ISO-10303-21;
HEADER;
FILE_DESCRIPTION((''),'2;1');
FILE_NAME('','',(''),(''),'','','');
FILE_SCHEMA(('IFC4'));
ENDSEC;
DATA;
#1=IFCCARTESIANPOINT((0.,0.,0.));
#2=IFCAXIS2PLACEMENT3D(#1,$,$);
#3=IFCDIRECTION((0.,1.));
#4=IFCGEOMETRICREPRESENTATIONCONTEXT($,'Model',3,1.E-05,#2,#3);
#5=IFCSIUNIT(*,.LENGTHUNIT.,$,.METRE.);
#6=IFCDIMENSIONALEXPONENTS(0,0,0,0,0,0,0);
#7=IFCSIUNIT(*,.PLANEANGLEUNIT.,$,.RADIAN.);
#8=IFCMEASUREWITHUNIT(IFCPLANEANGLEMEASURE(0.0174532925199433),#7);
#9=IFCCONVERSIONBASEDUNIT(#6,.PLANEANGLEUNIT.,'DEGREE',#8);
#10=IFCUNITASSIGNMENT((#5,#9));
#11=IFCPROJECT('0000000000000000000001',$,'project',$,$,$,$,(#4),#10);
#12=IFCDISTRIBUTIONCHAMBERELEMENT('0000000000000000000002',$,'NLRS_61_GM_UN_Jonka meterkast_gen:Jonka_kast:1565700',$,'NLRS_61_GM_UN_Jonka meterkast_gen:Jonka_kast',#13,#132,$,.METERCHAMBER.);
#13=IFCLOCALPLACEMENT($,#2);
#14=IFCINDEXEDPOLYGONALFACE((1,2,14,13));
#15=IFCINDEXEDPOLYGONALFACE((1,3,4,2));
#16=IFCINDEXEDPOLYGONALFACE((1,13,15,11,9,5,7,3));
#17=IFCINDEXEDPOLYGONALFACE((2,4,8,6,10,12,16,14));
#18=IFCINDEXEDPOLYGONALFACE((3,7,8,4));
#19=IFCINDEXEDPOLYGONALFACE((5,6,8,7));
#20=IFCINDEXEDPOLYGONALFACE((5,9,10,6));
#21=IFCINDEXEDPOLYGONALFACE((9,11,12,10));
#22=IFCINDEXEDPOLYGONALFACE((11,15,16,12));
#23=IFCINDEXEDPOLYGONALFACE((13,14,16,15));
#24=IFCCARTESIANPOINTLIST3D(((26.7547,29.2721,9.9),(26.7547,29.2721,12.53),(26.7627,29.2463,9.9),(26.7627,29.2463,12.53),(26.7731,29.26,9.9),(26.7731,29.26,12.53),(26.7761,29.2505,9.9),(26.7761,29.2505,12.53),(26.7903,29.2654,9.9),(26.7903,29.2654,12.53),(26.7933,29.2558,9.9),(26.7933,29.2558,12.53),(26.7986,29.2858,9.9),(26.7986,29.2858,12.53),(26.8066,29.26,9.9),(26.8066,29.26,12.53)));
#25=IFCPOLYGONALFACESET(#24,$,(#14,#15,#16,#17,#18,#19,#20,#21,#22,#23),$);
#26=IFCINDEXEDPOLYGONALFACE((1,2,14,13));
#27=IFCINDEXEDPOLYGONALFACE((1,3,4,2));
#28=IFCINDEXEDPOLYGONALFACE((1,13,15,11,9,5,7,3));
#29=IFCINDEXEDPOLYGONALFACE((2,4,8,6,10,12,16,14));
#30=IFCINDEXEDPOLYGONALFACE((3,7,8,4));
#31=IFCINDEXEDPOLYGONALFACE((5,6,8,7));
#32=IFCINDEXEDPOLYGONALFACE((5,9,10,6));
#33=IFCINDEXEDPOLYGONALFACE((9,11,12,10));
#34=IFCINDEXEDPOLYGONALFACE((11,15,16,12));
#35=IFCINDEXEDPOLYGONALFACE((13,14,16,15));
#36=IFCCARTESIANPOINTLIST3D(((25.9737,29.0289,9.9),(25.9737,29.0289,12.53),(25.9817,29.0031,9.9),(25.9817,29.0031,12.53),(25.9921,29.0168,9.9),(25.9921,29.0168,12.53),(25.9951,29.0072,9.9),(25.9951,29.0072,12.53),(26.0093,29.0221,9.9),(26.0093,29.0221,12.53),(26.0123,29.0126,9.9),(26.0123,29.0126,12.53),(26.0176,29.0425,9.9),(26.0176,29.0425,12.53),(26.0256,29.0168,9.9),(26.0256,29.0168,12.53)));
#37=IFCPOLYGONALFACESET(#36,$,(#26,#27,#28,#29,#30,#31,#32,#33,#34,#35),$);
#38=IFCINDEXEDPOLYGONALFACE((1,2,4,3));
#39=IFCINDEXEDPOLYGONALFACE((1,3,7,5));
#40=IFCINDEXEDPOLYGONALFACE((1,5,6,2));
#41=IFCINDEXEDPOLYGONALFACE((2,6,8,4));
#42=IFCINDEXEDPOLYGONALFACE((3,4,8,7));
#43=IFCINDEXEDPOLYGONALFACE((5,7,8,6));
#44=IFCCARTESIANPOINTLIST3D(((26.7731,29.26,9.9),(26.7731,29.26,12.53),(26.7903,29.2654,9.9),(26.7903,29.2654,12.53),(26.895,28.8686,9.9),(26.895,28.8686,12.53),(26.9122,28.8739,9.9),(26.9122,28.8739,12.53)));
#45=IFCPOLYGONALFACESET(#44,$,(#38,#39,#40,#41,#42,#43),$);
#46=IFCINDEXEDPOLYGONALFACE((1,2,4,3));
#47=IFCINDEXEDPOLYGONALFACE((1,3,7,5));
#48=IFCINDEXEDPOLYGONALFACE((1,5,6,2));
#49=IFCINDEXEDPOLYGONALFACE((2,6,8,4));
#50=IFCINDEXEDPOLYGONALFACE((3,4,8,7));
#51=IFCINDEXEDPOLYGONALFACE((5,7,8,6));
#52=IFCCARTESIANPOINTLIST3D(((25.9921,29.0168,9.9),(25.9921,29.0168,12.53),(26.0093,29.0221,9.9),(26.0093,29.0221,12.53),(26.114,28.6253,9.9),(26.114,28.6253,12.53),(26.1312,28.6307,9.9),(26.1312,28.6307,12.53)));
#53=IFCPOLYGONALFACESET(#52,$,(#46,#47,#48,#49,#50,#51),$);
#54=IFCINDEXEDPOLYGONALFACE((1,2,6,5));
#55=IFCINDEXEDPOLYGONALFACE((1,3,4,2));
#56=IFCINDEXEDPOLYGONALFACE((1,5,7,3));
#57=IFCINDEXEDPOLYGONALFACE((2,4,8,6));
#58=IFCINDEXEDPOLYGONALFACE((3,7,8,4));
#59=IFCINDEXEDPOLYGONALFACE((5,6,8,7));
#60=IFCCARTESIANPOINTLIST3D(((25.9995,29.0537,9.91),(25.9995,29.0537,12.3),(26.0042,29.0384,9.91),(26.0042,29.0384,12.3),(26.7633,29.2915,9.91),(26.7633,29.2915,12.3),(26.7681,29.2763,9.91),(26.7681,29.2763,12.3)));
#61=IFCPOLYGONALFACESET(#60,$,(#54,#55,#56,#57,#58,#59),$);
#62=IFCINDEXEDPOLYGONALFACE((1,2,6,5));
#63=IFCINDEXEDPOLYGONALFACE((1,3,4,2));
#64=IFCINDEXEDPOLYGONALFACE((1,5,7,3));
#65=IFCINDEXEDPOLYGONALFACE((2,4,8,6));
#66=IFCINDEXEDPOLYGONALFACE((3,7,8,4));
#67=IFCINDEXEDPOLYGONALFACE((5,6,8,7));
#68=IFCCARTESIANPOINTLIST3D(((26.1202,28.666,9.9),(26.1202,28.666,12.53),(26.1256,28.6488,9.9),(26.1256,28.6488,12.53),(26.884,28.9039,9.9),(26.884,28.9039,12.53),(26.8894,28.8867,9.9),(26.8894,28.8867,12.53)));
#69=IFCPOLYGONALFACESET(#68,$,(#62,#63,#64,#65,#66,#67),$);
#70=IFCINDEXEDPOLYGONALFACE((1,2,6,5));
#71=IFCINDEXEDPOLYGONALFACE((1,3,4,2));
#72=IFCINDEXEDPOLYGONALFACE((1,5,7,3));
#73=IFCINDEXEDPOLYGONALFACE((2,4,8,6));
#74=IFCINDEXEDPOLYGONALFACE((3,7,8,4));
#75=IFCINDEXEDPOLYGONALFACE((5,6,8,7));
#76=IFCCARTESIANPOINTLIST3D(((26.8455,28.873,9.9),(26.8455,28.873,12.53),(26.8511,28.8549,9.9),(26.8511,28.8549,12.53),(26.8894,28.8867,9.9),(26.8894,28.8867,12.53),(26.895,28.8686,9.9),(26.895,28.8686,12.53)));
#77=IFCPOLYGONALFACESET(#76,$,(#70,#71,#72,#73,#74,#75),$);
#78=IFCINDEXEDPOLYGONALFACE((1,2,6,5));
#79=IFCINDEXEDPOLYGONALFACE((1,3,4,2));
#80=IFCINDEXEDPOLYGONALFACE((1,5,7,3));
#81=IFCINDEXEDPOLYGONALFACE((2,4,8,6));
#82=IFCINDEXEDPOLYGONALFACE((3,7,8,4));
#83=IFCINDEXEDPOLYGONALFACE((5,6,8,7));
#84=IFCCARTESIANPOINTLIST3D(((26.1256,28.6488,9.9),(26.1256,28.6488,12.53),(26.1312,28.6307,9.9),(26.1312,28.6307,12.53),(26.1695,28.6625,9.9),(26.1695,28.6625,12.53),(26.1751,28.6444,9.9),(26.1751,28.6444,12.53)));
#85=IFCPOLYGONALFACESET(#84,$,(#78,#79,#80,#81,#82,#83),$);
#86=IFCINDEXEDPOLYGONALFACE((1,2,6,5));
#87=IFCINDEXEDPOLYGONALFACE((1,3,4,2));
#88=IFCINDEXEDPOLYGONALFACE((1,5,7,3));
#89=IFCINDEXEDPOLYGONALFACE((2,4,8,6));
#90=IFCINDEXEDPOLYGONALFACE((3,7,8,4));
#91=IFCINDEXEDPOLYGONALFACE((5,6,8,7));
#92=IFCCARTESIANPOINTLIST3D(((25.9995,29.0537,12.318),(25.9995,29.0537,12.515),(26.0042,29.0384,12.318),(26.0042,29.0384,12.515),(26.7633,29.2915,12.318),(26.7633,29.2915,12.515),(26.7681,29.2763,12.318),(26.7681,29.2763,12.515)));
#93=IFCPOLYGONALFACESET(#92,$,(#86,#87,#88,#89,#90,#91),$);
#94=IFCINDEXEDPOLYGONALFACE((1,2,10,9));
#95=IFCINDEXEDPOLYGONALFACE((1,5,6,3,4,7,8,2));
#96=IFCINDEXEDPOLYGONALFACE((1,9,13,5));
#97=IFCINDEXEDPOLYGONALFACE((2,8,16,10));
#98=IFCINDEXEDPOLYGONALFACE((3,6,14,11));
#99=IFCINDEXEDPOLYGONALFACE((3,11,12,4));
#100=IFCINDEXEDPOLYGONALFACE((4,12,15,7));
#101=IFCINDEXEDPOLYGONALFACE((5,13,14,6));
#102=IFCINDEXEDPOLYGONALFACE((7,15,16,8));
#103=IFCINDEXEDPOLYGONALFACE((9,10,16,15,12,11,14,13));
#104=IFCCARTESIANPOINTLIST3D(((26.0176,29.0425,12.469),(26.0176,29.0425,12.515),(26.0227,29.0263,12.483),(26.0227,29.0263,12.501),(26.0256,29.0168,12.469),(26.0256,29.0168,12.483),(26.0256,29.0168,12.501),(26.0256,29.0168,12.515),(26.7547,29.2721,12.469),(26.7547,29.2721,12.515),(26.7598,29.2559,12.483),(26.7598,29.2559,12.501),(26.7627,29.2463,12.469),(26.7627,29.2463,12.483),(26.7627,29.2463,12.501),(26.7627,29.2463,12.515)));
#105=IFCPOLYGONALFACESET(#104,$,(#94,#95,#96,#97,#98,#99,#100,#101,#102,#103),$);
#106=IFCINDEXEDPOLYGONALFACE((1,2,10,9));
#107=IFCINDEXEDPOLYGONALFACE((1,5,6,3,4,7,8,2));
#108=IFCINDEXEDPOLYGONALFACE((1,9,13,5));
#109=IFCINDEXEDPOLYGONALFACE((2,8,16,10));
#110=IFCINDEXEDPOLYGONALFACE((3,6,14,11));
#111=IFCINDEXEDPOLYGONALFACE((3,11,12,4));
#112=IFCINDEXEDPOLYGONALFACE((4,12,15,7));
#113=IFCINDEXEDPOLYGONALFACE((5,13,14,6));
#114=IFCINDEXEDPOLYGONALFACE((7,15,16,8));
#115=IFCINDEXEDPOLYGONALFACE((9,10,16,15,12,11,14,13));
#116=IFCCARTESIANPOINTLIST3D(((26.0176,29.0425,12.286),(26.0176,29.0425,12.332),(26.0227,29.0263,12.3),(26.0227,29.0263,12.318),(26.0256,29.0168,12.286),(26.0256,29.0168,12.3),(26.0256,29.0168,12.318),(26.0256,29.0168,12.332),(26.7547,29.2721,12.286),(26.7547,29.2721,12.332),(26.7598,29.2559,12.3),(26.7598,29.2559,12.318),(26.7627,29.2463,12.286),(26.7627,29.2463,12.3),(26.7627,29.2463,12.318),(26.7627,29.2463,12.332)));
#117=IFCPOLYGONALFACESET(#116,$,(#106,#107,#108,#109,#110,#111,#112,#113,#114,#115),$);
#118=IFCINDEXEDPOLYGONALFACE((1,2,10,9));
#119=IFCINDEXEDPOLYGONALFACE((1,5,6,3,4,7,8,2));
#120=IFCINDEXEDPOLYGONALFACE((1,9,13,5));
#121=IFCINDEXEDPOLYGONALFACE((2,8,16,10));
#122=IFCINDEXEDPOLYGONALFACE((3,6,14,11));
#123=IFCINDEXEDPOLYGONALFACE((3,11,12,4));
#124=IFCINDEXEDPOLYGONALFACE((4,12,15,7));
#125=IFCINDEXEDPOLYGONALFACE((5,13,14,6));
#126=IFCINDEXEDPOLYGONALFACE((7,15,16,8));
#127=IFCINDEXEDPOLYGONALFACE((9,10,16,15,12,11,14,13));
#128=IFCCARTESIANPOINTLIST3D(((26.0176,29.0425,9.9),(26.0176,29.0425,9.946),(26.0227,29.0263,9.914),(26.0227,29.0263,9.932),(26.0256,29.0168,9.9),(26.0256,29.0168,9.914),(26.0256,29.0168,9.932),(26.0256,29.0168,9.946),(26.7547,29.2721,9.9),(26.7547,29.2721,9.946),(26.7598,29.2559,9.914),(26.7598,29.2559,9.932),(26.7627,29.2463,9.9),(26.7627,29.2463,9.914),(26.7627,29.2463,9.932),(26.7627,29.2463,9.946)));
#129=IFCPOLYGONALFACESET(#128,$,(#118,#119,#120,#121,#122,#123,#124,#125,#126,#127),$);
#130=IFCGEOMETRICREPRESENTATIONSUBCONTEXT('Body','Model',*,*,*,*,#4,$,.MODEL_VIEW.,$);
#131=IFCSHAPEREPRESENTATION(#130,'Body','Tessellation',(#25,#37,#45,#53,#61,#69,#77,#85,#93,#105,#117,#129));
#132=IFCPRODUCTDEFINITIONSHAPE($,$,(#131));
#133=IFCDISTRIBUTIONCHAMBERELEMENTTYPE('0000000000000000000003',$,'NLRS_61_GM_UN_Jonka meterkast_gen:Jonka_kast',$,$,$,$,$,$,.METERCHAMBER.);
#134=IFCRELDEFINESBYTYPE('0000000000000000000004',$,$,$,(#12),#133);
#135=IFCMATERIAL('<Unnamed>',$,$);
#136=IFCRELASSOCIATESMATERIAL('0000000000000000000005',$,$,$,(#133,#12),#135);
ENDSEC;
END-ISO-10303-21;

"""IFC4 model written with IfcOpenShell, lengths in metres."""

from ifc_helpers import new_model, entity, si_unit, converted_unit, direction, frame, origin, place, context, subcontext, project, indexed_curve, outline, extrude, source, transform, mapped, material, type_object, type_shapes, element, save


model = new_model("IFC4")

# Units and contexts
model_context = context("Model", 3, precision=1e-05, world=origin(), true_north=direction((0.0, 1.0)))
body_context = subcontext(model_context, "Body", "Model", "MODEL_VIEW")
ifc_project = project(units=[si_unit("LENGTHUNIT", "METRE"), converted_unit("PLANEANGLEUNIT", "DEGREE", entity("IfcPlaneAngleMeasure", 0.0174532925199433), si_unit("PLANEANGLEUNIT", "RADIAN"), dimensions=[0, 0, 0, 0, 0, 0, 0])], contexts=[model_context])

# Distribution chamber element
ifc_material = material(Name="<Unnamed>")
distribution_chamber_element_type = type_object("IfcDistributionChamberElementType", Name="NLRS_61_GM_UN_Jonka meterkast_gen:Jonka_kast", PredefinedType="METERCHAMBER", material=ifc_material)
shared_shape_1 = source(origin(), body_context, "Body", "SweptSolid", [
    extrude(outline(indexed_curve([(-0.0093, -0.023), (0.0178, -0.023), (0.0178, 0.023), (-0.0093, 0.023), (-0.0093, 0.009), (0.0007, 0.009), (0.0007, -0.009), (-0.0093, -0.009), (-0.0093, -0.023)], self_intersect=False)), frame((-0.409, -0.4092, 0.0), z_axis=(0.0, 0.0, 1.0), x_axis=(0.0, -1.0, 0.0)), (0.0, 0.0, 1.0), 2.63),
    extrude(outline(indexed_curve([(-0.0093, -0.023), (0.0178, -0.023), (0.0178, 0.023), (-0.0093, 0.023), (-0.0093, 0.009), (0.0007, 0.009), (0.0007, -0.009), (-0.0093, -0.009), (-0.0093, -0.023)], self_intersect=False)), frame((0.409, -0.4092, 0.0), z_axis=(0.0, 0.0, 1.0), x_axis=(0.0, -1.0, 0.0)), (0.0, 0.0, 1.0), 2.63),
    extrude(outline(indexed_curve([(-0.205, -0.009), (0.205, -0.009), (0.205, 0.009), (-0.205, 0.009), (-0.205, -0.009)], self_intersect=False)), frame((-0.409, -0.205, 0.0), z_axis=(0.0, 0.0, 1.0), x_axis=(0.0, -1.0, 0.0)), (0.0, 0.0, 1.0), 2.63),
    extrude(outline(indexed_curve([(-0.205, -0.009), (0.205, -0.009), (0.205, 0.009), (-0.205, 0.009), (-0.205, -0.009)], self_intersect=False)), frame((0.409, -0.205, 0.0), z_axis=(0.0, 0.0, 1.0), x_axis=(0.0, -1.0, 0.0)), (0.0, 0.0, 1.0), 2.63),
    extrude(outline(indexed_curve([(-0.4, -0.008), (0.4, -0.008), (0.4, 0.008), (-0.4, 0.008), (-0.4, -0.008)], self_intersect=False)), frame((0.0, -0.435, 0.01), z_axis=(0.0, 0.0, 1.0), x_axis=(-1.0, 0.0, 0.0)), (0.0, 0.0, 1.0), 2.39),
    extrude(outline(indexed_curve([(-0.4, -0.009), (0.4, -0.009), (0.4, 0.009), (-0.4, 0.009), (-0.4, -0.009)], self_intersect=False)), frame((0.0, -0.028, 0.0), z_axis=(0.0, 0.0, 1.0), x_axis=(-1.0, 0.0, 0.0)), (0.0, 0.0, 1.0), 2.63),
    extrude(outline(indexed_curve([(-0.023, -0.0095), (0.023, -0.0095), (0.023, 0.0095), (-0.023, 0.0095), (-0.023, -0.0095)], self_intersect=False)), frame((-0.377, -0.0095, 0.0), z_axis=(0.0, 0.0, 1.0), x_axis=(-1.0, 0.0, 0.0)), (0.0, 0.0, 1.0), 2.63),
    extrude(outline(indexed_curve([(-0.023, -0.0095), (0.023, -0.0095), (0.023, 0.0095), (-0.023, 0.0095), (-0.023, -0.0095)], self_intersect=False)), frame((0.377, -0.0095, 0.0), z_axis=(0.0, 0.0, 1.0), x_axis=(-1.0, 0.0, 0.0)), (0.0, 0.0, 1.0), 2.63),
    extrude(outline(indexed_curve([(-0.4, -0.008), (0.4, -0.008), (0.4, 0.008), (-0.4, 0.008), (-0.4, -0.008)], self_intersect=False)), frame((0.0, -0.435, 2.418), z_axis=(0.0, 0.0, 1.0), x_axis=(-1.0, 0.0, 0.0)), (0.0, 0.0, 1.0), 0.197),
    extrude(outline(indexed_curve([(-0.023, -0.0178), (0.023, -0.0178), (0.023, 0.0093), (0.009, 0.0093), (0.009, -0.0007), (-0.009, -0.0007), (-0.009, 0.0093), (-0.023, 0.0093), (-0.023, -0.0178)], self_intersect=False)), frame((-0.386, -0.4092, 2.592), z_axis=(1.0, 0.0, 0.0), x_axis=(0.0, 0.0, -1.0)), (0.0, 0.0, 1.0), 0.772),
    extrude(outline(indexed_curve([(-0.023, -0.0178), (0.023, -0.0178), (0.023, 0.0093), (0.009, 0.0093), (0.009, -0.0007), (-0.009, -0.0007), (-0.009, 0.0093), (-0.023, 0.0093), (-0.023, -0.0178)], self_intersect=False)), frame((-0.386, -0.4092, 2.409), z_axis=(1.0, 0.0, 0.0), x_axis=(0.0, 0.0, -1.0)), (0.0, 0.0, 1.0), 0.772),
    extrude(outline(indexed_curve([(-0.023, -0.0178), (0.023, -0.0178), (0.023, 0.0093), (0.009, 0.0093), (0.009, -0.0007), (-0.009, -0.0007), (-0.009, 0.0093), (-0.023, 0.0093), (-0.023, -0.0178)], self_intersect=False)), frame((-0.386, -0.4092, 0.023), z_axis=(1.0, 0.0, 0.0), x_axis=(0.0, 0.0, -1.0)), (0.0, 0.0, 1.0), 0.772),
])
type_shapes(distribution_chamber_element_type, [shared_shape_1])
placement_1 = place(None, frame((13.1348, 11.9886, 0.0), z_axis=(0.0, 0.0, 1.0), x_axis=(0.954771, 0.297342, 0.0)))
placement_2 = place(placement_1, origin())
placement_3 = place(placement_2, frame((0.0, 0.0, 9.9)))
placement_4 = place(placement_3, origin())
distribution_chamber_element_1_placement = place(placement_4, frame((17.757, 12.025, 0.0), z_axis=(0.0, 0.0, 1.0), x_axis=(-1.0, 0.0, 0.0)))
element("IfcDistributionChamberElement", 1, at=distribution_chamber_element_1_placement, type_object=distribution_chamber_element_type, material=ifc_material, Name="NLRS_61_GM_UN_Jonka meterkast_gen:Jonka_kast:1565700", ObjectType="NLRS_61_GM_UN_Jonka meterkast_gen:Jonka_kast", PredefinedType="METERCHAMBER", context=body_context, shape_type="MappedRepresentation", body=[
    mapped(shared_shape_1, transform((0.0, 0.0, 0.0), scale=1.0)),
])

save(model, "model.ifc")
